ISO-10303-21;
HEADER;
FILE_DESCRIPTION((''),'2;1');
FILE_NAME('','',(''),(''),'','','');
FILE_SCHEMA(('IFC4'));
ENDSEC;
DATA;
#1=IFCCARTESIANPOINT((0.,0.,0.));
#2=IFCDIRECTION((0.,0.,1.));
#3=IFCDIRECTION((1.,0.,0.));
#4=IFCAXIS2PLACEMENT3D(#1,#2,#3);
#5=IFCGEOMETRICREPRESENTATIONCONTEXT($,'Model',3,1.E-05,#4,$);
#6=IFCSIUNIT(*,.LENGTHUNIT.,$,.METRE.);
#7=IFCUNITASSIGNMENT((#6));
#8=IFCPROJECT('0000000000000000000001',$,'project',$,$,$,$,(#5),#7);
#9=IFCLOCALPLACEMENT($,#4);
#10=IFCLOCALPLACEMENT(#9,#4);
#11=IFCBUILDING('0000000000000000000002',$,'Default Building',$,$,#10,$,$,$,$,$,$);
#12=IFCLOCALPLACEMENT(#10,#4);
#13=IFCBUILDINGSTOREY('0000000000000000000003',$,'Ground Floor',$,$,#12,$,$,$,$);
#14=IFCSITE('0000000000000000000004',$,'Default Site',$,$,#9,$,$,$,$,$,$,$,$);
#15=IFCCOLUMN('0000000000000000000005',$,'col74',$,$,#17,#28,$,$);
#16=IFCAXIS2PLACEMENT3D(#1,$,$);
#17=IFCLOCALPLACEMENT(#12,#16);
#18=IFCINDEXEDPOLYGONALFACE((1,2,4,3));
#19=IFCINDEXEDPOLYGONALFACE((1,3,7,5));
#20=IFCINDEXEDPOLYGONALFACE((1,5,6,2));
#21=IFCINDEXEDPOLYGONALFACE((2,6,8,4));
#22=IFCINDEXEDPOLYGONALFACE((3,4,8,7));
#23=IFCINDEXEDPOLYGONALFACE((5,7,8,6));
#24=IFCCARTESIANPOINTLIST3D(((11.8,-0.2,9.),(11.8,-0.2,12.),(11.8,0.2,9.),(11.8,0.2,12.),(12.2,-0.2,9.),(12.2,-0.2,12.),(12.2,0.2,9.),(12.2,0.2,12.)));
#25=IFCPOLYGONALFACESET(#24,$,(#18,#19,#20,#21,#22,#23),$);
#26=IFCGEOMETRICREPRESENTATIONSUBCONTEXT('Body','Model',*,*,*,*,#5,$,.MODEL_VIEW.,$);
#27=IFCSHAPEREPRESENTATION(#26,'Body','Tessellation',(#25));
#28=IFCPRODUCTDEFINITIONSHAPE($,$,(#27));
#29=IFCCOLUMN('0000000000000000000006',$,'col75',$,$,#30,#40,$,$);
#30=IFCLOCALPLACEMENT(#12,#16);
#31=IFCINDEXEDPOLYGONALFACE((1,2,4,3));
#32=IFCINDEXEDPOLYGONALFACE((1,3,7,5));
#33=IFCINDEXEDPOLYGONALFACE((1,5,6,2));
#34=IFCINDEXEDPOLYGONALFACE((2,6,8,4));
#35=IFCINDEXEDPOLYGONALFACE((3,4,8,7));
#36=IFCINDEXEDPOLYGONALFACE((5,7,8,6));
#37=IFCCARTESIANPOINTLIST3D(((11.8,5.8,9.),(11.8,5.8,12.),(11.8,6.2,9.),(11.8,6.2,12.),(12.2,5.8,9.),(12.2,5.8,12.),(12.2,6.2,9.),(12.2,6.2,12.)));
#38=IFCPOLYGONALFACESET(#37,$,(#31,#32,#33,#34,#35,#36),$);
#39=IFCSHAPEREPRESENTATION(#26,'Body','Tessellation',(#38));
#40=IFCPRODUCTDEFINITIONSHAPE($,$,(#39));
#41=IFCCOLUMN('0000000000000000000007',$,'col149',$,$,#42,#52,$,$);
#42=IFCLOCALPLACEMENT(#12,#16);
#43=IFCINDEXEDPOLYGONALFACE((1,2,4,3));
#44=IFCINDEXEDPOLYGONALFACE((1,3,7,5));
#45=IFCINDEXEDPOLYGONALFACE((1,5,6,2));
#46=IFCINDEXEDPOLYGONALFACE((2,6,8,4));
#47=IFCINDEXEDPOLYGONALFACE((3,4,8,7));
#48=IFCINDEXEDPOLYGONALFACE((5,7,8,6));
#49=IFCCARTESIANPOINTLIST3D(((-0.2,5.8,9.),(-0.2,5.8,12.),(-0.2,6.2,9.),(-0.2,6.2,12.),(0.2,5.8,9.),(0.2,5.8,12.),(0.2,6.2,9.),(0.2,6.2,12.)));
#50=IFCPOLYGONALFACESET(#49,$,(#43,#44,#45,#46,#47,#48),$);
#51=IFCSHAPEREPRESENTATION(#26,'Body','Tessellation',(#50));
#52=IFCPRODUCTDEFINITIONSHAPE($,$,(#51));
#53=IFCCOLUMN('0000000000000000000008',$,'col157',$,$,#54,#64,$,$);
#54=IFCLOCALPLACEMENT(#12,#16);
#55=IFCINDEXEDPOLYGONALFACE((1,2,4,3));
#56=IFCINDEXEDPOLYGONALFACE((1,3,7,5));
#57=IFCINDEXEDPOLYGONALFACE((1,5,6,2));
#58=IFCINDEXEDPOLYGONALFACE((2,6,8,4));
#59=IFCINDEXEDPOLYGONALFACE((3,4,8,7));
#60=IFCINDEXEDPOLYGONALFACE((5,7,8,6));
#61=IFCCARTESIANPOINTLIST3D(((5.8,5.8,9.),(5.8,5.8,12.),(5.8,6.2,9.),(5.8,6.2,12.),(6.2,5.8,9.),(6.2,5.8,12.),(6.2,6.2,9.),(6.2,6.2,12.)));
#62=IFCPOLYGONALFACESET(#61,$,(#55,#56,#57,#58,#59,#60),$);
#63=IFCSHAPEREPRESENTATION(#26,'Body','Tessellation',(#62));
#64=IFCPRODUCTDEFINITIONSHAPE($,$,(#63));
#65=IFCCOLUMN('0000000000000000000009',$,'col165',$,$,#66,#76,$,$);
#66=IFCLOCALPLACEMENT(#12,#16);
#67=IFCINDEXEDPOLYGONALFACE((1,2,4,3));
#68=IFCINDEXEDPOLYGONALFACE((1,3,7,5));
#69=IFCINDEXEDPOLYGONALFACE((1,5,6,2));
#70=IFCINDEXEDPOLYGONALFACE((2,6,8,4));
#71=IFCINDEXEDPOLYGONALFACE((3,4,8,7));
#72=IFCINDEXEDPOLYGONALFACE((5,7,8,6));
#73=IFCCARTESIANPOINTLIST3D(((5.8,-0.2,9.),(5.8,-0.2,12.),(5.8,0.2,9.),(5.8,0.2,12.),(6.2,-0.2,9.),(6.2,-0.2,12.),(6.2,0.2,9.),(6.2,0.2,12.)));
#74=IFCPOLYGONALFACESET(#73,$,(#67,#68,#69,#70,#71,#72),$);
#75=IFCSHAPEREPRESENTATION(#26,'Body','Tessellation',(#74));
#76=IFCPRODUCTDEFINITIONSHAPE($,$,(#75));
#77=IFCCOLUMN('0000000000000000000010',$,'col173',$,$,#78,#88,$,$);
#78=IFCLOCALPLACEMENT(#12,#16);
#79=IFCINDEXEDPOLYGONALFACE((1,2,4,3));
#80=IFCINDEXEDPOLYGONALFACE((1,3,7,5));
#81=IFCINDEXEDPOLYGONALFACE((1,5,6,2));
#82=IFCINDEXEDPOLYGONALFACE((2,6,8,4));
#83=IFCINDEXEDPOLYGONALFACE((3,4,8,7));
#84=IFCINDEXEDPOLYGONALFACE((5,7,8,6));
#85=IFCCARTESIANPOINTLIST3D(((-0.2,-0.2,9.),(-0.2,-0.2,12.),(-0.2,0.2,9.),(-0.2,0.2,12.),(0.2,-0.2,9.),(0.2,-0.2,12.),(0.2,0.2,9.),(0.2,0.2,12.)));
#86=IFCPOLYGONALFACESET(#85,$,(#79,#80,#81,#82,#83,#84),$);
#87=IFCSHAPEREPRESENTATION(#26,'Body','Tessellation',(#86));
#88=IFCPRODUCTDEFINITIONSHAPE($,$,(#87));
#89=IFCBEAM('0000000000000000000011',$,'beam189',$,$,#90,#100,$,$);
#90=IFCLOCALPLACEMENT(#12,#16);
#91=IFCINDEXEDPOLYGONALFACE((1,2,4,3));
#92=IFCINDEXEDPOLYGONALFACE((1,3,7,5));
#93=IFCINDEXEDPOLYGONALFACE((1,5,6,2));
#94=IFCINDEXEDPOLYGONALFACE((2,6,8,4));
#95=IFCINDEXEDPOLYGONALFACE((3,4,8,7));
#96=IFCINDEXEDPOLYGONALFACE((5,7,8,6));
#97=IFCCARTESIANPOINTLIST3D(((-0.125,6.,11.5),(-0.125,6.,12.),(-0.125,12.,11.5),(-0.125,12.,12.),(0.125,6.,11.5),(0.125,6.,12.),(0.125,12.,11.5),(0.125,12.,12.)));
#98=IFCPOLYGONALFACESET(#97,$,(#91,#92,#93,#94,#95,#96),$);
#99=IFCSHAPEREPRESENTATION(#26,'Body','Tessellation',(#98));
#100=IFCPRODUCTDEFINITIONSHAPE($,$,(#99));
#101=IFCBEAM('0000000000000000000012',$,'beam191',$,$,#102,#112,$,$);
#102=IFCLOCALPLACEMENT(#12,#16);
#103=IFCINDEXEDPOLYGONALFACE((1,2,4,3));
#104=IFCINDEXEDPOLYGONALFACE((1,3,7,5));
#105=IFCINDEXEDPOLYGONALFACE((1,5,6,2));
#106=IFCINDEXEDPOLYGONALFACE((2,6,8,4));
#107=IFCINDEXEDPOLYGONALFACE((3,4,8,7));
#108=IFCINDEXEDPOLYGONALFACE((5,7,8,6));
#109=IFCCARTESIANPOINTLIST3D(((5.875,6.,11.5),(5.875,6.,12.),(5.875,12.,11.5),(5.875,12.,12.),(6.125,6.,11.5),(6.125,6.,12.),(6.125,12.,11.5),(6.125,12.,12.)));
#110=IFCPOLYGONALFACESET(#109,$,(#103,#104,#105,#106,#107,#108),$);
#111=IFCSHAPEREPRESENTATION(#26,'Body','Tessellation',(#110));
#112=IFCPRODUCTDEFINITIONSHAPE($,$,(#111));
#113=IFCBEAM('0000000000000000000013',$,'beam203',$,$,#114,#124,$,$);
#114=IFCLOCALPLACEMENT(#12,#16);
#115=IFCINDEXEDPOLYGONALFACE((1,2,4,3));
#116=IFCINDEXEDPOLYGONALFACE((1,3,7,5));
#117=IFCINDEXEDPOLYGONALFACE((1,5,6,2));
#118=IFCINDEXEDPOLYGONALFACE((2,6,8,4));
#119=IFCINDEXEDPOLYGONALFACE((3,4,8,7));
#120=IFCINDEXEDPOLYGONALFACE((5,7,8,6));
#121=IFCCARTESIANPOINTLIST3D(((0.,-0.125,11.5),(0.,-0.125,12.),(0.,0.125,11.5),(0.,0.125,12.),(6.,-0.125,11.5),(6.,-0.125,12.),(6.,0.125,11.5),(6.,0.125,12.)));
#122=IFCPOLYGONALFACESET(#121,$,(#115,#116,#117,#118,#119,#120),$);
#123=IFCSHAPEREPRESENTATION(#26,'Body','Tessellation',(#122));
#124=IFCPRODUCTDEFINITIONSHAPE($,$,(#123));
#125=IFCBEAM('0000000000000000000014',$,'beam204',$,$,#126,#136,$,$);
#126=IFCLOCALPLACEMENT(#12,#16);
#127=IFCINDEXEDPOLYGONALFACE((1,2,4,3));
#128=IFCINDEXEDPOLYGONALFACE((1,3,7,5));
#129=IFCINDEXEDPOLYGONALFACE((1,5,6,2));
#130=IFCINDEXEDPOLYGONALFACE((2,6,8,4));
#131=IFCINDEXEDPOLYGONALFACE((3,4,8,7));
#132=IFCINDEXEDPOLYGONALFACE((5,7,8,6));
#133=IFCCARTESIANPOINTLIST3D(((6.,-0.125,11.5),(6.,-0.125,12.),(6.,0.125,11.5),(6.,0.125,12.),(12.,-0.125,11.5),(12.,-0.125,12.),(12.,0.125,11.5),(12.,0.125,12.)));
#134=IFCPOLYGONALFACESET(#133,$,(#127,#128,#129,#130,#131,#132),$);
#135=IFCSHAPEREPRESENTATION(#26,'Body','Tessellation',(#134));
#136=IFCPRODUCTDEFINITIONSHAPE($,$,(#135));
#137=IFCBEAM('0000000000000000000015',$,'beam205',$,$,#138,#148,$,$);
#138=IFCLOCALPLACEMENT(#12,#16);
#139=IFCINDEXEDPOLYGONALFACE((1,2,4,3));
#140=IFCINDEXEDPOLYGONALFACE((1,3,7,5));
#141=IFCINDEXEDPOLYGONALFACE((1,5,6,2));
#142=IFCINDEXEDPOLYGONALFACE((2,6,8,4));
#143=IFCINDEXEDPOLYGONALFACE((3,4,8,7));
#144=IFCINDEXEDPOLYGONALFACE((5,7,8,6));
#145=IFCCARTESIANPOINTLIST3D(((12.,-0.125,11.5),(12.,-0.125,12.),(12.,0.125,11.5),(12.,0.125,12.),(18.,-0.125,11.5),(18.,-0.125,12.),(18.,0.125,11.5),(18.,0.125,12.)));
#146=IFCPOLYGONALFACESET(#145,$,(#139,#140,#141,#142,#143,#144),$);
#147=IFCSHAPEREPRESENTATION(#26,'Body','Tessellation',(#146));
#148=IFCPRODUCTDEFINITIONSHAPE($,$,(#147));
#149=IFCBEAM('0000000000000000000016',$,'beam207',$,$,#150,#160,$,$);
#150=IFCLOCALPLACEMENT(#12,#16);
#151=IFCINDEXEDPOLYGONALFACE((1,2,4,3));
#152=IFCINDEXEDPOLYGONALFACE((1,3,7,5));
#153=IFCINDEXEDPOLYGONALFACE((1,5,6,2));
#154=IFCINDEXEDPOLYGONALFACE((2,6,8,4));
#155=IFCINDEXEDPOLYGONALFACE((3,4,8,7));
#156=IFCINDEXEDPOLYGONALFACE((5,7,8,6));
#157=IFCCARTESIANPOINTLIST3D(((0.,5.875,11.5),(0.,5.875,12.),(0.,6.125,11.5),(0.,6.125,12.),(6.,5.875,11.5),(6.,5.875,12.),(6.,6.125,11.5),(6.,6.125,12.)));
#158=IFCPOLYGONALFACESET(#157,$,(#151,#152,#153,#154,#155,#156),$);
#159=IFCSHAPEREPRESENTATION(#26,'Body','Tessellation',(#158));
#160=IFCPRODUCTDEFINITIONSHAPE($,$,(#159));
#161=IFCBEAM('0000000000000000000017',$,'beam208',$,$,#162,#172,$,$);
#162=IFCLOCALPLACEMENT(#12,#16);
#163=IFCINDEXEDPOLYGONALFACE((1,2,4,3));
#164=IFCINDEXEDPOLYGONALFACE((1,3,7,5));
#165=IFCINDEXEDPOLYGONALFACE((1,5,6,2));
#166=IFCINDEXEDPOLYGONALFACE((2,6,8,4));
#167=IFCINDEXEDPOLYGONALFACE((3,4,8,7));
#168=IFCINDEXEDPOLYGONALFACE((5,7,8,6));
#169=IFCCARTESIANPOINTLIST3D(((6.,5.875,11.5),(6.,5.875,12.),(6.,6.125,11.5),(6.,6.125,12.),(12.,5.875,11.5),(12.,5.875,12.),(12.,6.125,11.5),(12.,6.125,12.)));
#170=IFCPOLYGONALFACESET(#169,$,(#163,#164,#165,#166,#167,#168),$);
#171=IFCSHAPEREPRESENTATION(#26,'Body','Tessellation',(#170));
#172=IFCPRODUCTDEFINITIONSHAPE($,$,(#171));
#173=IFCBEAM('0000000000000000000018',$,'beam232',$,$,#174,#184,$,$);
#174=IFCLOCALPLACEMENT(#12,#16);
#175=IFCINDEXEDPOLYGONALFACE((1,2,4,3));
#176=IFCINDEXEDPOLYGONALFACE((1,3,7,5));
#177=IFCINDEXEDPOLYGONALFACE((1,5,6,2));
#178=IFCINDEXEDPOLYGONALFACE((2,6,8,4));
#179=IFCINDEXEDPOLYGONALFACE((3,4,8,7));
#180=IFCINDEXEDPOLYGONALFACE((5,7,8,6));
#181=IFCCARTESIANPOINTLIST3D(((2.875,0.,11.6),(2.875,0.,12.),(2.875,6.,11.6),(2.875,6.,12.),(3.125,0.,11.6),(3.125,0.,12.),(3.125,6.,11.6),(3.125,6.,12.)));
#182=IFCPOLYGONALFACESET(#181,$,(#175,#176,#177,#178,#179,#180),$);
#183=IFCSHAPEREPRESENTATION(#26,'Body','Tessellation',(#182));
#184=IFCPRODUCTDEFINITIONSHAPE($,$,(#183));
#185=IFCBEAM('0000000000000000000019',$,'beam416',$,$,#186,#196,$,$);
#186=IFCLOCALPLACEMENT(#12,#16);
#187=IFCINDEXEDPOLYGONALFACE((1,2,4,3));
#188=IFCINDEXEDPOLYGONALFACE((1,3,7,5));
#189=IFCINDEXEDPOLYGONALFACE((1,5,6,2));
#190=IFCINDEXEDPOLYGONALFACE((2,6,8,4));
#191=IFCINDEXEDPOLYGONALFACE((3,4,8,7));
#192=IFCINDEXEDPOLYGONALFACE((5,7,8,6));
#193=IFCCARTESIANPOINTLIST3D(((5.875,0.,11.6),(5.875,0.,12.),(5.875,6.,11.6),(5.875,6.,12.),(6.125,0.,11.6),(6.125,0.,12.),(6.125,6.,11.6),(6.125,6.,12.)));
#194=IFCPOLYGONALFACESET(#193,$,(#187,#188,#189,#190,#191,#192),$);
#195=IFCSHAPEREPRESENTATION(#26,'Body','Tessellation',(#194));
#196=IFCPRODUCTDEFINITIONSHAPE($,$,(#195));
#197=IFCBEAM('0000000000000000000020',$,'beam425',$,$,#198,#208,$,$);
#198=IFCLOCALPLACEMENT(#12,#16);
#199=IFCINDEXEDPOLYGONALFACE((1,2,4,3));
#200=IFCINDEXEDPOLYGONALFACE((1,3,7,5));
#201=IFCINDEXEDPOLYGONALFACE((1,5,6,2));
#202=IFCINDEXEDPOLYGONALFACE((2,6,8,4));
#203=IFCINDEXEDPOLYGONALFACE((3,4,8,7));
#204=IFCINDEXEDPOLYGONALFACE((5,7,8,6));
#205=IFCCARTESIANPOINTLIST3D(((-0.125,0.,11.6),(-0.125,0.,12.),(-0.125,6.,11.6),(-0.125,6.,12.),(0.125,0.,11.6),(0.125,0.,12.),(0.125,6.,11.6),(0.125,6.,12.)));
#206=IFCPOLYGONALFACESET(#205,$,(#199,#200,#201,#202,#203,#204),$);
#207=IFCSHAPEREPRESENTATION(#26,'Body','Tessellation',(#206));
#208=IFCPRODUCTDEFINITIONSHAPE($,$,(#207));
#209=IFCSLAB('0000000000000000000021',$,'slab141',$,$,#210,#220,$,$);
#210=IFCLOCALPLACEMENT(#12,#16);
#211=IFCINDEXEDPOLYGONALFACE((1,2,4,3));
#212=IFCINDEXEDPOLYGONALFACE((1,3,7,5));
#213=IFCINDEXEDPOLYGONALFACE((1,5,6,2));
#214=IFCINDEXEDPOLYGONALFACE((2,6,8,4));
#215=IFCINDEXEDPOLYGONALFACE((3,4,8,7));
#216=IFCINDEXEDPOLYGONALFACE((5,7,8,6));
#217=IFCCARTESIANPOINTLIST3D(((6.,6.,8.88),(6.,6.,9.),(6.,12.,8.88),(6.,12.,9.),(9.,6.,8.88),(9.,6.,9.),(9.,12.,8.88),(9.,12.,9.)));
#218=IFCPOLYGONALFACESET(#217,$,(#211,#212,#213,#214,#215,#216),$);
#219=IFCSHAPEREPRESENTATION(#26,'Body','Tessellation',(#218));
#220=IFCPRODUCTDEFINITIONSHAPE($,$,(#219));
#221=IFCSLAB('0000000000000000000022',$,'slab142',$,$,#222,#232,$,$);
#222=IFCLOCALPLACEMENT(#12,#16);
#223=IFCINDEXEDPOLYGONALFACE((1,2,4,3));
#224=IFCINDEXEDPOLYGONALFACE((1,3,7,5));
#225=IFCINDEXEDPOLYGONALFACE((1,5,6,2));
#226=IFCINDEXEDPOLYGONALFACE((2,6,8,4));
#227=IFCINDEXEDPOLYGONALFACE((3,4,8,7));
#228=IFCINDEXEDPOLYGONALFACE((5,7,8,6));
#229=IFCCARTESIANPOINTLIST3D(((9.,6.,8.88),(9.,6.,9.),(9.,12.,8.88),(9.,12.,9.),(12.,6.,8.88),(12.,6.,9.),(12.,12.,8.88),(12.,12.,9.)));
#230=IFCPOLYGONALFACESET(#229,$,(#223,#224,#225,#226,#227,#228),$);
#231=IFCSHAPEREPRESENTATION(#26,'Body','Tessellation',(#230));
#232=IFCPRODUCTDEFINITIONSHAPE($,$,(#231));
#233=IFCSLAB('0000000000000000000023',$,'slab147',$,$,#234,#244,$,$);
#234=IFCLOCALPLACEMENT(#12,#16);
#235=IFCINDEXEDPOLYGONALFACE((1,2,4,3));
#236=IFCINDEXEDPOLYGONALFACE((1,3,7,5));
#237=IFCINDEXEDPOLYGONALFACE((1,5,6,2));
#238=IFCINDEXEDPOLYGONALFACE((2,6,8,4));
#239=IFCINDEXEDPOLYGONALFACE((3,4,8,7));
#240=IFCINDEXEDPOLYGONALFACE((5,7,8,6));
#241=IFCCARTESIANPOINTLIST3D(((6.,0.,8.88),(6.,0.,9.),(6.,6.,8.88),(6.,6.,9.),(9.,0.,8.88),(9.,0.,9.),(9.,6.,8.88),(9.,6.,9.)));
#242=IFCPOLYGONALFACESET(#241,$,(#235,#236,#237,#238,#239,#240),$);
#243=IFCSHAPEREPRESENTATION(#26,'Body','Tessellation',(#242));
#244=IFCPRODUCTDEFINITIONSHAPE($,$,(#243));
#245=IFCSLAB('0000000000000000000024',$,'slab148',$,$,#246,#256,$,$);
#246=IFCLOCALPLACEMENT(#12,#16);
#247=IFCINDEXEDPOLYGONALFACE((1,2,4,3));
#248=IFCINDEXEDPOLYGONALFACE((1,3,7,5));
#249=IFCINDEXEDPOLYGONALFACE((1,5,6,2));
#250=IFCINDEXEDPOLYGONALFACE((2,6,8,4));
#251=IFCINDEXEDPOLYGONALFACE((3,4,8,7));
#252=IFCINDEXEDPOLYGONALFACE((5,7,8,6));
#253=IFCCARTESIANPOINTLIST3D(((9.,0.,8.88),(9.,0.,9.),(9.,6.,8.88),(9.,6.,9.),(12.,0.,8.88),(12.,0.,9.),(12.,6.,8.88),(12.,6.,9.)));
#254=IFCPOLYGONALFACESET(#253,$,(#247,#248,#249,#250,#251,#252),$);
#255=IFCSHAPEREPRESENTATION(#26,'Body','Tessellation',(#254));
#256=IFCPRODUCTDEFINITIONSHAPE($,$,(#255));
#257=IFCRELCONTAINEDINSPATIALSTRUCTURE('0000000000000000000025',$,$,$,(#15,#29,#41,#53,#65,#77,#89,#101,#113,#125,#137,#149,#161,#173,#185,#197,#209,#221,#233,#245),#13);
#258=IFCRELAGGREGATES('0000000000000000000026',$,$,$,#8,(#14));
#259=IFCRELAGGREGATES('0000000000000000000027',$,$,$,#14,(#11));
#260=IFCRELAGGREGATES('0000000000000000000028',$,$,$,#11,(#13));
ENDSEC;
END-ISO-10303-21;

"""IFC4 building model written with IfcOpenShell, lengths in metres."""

from ifc_helpers import new_model, si_unit, frame, origin_with_axes, place, context, subcontext, project, spatial, indexed_curve, outline, extrude, element, save


model = new_model("IFC4")

# Units and contexts
model_context = context("Model", 3, precision=1e-05, world=origin_with_axes())
body_context = subcontext(model_context, "Body", "Model", "MODEL_VIEW")
ifc_project = project(units=[si_unit("LENGTHUNIT", "METRE")], contexts=[model_context])

# Site, building, storey
site_placement = place(None, origin_with_axes())
site = spatial("IfcSite", under=ifc_project, at=site_placement, Name="Default Site")
building_placement = place(site_placement, origin_with_axes())
building = spatial("IfcBuilding", under=site, at=building_placement, Name="Default Building")
storey_placement = place(building_placement, origin_with_axes())
storey = spatial("IfcBuildingStorey", under=building, at=storey_placement, Name="Ground Floor")

# Columns
for number, where, z_axis, x_axis, name in (
    (1, (11.8, -0.2, 9.0), (0.0, 0.0, 1.0), (1.0, 0.0, 0.0), "col74"),
    (2, (11.8, 5.8, 9.0), (0.0, 0.0, 1.0), (1.0, 0.0, 0.0), "col75"),
    (3, (-0.2, 5.8, 9.0), (0.0, 0.0, 1.0), (1.0, 0.0, 0.0), "col149"),
    (4, (5.8, 5.8, 9.0), (0.0, 0.0, 1.0), (1.0, 0.0, 0.0), "col157"),
    (5, (5.8, -0.2, 9.0), (0.0, 0.0, 1.0), (1.0, 0.0, 0.0), "col165"),
    (6, (-0.2, -0.2, 9.0), (0.0, 0.0, 1.0), (1.0, 0.0, 0.0), "col173"),
):
    element("IfcColumn", number, at=place(storey_placement, frame(where, z_axis=z_axis, x_axis=x_axis)), inside=storey, Name=name, context=body_context, shape_type="SweptSolid", body=[
        extrude(outline(indexed_curve([(0.0, 0.0), (0.0, 0.4), (0.4, 0.4), (0.4, 0.0), (0.0, 0.0)], self_intersect=False)), origin_with_axes(), (0.0, 0.0, 1.0), 3.0),
    ])

# Beams
for number, where, z_axis, x_axis, name in (
    (7, (0.125, 6.0, 11.5), (0.0, 0.0, 1.0), (0.0, 1.0, 0.0), "beam189"),
    (8, (6.125, 6.0, 11.5), (0.0, 0.0, 1.0), (0.0, 1.0, 0.0), "beam191"),
    (9, (0.0, -0.125, 11.5), (0.0, 0.0, 1.0), (1.0, 0.0, 0.0), "beam203"),
    (10, (6.0, -0.125, 11.5), (0.0, 0.0, 1.0), (1.0, 0.0, 0.0), "beam204"),
    (11, (12.0, -0.125, 11.5), (0.0, 0.0, 1.0), (1.0, 0.0, 0.0), "beam205"),
    (12, (0.0, 5.875, 11.5), (0.0, 0.0, 1.0), (1.0, 0.0, 0.0), "beam207"),
    (13, (6.0, 5.875, 11.5), (0.0, 0.0, 1.0), (1.0, 0.0, 0.0), "beam208"),
):
    element("IfcBeam", number, at=place(storey_placement, frame(where, z_axis=z_axis, x_axis=x_axis)), inside=storey, Name=name, context=body_context, shape_type="SweptSolid", body=[
        extrude(outline(indexed_curve([(0.0, 0.0), (0.0, 0.25), (6.0, 0.25), (6.0, 0.0), (0.0, 0.0)], self_intersect=False)), origin_with_axes(), (0.0, 0.0, 1.0), 0.5),
    ])
for number, where, z_axis, x_axis, name in (
    (14, (2.875, 6.0, 11.6), (0.0, 0.0, 1.0), (0.0, -1.0, 0.0), "beam232"),
    (15, (5.875, 6.0, 11.6), (0.0, 0.0, 1.0), (0.0, -1.0, 0.0), "beam416"),
    (16, (-0.125, 6.0, 11.6), (0.0, 0.0, 1.0), (0.0, -1.0, 0.0), "beam425"),
):
    element("IfcBeam", number, at=place(storey_placement, frame(where, z_axis=z_axis, x_axis=x_axis)), inside=storey, Name=name, context=body_context, shape_type="SweptSolid", body=[
        extrude(outline(indexed_curve([(0.0, 0.0), (0.0, 0.25), (6.0, 0.25), (6.0, 0.0), (0.0, 0.0)], self_intersect=False)), origin_with_axes(), (0.0, 0.0, 1.0), 0.4),
    ])

# Slabs
for number, where, z_axis, x_axis, name in (
    (17, (6.0, 6.0, 8.88), (0.0, 0.0, 1.0), (1.0, 0.0, 0.0), "slab141"),
    (18, (9.0, 6.0, 8.88), (0.0, 0.0, 1.0), (1.0, 0.0, 0.0), "slab142"),
    (19, (6.0, 0.0, 8.88), (0.0, 0.0, 1.0), (1.0, 0.0, 0.0), "slab147"),
    (20, (9.0, 0.0, 8.88), (0.0, 0.0, 1.0), (1.0, 0.0, 0.0), "slab148"),
):
    element("IfcSlab", number, at=place(storey_placement, frame(where, z_axis=z_axis, x_axis=x_axis)), inside=storey, Name=name, context=body_context, shape_type="SweptSolid", body=[
        extrude(outline(indexed_curve([(0.0, 0.0), (0.0, 6.0), (3.0, 6.0), (3.0, 0.0), (0.0, 0.0)], self_intersect=False)), origin_with_axes(), (0.0, 0.0, 1.0), 0.12),
    ])

save(model, "model.ifc")
